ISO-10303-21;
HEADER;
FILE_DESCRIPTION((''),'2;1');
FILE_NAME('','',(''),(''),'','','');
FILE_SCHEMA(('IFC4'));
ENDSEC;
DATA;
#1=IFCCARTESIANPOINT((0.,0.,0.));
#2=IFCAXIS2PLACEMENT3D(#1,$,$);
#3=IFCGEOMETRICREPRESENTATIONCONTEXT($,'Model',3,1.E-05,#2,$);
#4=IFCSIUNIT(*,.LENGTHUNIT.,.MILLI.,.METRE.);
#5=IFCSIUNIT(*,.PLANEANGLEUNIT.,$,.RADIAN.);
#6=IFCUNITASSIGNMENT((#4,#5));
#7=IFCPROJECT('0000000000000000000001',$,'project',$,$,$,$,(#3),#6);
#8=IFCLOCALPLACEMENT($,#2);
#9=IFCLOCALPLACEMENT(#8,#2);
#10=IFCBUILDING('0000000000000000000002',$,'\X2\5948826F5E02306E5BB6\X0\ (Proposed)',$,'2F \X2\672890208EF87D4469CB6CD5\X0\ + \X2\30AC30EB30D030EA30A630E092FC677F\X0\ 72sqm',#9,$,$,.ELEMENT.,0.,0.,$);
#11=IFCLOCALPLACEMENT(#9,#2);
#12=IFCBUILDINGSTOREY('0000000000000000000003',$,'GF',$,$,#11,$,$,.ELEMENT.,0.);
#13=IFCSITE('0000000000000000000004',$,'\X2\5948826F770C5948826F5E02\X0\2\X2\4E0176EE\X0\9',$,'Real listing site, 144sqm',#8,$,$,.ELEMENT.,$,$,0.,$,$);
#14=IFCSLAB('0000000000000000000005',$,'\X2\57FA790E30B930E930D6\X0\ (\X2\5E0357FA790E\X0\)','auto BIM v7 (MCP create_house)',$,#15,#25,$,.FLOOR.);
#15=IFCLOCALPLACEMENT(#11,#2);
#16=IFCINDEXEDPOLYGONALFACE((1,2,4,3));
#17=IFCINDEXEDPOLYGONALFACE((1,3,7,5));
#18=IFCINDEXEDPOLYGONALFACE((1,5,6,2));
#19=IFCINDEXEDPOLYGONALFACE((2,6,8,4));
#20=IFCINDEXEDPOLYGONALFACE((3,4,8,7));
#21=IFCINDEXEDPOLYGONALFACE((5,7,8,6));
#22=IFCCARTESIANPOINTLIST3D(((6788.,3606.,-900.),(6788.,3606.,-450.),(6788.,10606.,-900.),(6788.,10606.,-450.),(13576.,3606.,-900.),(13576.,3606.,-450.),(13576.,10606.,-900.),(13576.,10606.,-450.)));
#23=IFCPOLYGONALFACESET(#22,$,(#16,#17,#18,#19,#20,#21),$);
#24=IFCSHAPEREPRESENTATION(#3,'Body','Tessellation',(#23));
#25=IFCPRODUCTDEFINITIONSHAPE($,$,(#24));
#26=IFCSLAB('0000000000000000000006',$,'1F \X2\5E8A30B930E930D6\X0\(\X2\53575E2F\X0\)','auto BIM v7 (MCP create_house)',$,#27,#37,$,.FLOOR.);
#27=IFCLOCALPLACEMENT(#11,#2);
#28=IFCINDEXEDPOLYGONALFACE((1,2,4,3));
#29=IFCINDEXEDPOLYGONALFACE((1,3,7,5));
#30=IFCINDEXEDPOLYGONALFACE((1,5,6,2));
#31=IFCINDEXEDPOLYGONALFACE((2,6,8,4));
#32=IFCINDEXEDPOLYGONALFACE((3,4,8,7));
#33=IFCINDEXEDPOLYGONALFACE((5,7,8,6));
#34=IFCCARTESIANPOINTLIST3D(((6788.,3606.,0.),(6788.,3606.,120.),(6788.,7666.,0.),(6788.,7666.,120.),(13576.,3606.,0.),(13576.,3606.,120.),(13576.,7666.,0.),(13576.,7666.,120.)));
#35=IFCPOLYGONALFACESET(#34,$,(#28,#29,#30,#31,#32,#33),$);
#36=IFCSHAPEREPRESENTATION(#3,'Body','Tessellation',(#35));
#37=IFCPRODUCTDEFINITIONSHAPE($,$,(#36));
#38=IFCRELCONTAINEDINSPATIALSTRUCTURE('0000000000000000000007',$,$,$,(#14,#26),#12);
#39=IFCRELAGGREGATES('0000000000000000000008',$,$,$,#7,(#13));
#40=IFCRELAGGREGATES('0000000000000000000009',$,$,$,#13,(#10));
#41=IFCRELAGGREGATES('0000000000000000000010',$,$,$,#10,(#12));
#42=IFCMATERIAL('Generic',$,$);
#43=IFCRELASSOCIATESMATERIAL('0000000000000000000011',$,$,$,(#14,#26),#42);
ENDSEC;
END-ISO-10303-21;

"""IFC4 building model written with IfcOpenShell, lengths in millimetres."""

from ifc_helpers import new_model, si_unit, frame, frame_2d, origin, place, context, project, spatial, rectangle, extrude, material, element, save


model = new_model("IFC4")

# Units and contexts
model_context = context("Model", 3, precision=1e-05, world=origin())
ifc_project = project(units=[si_unit("LENGTHUNIT", "METRE", prefix="MILLI"), si_unit("PLANEANGLEUNIT", "RADIAN")], contexts=[model_context])

# Site, building, storey
site_placement = place(None, origin())
site = spatial("IfcSite", under=ifc_project, at=site_placement, Name="奈良県奈良市2丁目9", ObjectType="Real listing site, 144sqm", CompositionType="ELEMENT", RefElevation=0.0)
building_placement = place(site_placement, origin())
building = spatial("IfcBuilding", under=site, at=building_placement, Name="奈良市の家 (Proposed)", ObjectType="2F 木造軸組構法 + ガルバリウム鋼板 72sqm", CompositionType="ELEMENT", ElevationOfRefHeight=0.0, ElevationOfTerrain=0.0)
storey_placement = place(building_placement, origin())
storey = spatial("IfcBuildingStorey", under=building, at=storey_placement, Name="GF", CompositionType="ELEMENT", Elevation=0.0)

# Slabs
ifc_material = material(Name="Generic")
slab_1_placement = place(storey_placement, frame((3394.0, 1803.0, -450.0)))
element("IfcSlab", 1, at=slab_1_placement, inside=storey, material=ifc_material, Name="基礎スラブ (布基礎)", Description="auto BIM v7 (MCP create_house)", PredefinedType="FLOOR", context=model_context, shape_type="SweptSolid", body=[
    extrude(rectangle(XDim=6788.0, YDim=7000.0, at=frame_2d((3394.0, 3500.0))), frame((3394.0, 1803.0, -450.0)), (0.0, 0.0, 1.0), 450.0),
])
slab_2_placement = place(storey_placement, frame((3394.0, 1803.0, 0.0)))
element("IfcSlab", 2, at=slab_2_placement, inside=storey, material=ifc_material, Name="1F 床スラブ(南帯)", Description="auto BIM v7 (MCP create_house)", PredefinedType="FLOOR", context=model_context, shape_type="SweptSolid", body=[
    extrude(rectangle(XDim=6788.0, YDim=4060.0, at=frame_2d((3394.0, 2030.0))), frame((3394.0, 1803.0, 0.0)), (0.0, 0.0, 1.0), 120.0),
])

save(model, "model.ifc")
